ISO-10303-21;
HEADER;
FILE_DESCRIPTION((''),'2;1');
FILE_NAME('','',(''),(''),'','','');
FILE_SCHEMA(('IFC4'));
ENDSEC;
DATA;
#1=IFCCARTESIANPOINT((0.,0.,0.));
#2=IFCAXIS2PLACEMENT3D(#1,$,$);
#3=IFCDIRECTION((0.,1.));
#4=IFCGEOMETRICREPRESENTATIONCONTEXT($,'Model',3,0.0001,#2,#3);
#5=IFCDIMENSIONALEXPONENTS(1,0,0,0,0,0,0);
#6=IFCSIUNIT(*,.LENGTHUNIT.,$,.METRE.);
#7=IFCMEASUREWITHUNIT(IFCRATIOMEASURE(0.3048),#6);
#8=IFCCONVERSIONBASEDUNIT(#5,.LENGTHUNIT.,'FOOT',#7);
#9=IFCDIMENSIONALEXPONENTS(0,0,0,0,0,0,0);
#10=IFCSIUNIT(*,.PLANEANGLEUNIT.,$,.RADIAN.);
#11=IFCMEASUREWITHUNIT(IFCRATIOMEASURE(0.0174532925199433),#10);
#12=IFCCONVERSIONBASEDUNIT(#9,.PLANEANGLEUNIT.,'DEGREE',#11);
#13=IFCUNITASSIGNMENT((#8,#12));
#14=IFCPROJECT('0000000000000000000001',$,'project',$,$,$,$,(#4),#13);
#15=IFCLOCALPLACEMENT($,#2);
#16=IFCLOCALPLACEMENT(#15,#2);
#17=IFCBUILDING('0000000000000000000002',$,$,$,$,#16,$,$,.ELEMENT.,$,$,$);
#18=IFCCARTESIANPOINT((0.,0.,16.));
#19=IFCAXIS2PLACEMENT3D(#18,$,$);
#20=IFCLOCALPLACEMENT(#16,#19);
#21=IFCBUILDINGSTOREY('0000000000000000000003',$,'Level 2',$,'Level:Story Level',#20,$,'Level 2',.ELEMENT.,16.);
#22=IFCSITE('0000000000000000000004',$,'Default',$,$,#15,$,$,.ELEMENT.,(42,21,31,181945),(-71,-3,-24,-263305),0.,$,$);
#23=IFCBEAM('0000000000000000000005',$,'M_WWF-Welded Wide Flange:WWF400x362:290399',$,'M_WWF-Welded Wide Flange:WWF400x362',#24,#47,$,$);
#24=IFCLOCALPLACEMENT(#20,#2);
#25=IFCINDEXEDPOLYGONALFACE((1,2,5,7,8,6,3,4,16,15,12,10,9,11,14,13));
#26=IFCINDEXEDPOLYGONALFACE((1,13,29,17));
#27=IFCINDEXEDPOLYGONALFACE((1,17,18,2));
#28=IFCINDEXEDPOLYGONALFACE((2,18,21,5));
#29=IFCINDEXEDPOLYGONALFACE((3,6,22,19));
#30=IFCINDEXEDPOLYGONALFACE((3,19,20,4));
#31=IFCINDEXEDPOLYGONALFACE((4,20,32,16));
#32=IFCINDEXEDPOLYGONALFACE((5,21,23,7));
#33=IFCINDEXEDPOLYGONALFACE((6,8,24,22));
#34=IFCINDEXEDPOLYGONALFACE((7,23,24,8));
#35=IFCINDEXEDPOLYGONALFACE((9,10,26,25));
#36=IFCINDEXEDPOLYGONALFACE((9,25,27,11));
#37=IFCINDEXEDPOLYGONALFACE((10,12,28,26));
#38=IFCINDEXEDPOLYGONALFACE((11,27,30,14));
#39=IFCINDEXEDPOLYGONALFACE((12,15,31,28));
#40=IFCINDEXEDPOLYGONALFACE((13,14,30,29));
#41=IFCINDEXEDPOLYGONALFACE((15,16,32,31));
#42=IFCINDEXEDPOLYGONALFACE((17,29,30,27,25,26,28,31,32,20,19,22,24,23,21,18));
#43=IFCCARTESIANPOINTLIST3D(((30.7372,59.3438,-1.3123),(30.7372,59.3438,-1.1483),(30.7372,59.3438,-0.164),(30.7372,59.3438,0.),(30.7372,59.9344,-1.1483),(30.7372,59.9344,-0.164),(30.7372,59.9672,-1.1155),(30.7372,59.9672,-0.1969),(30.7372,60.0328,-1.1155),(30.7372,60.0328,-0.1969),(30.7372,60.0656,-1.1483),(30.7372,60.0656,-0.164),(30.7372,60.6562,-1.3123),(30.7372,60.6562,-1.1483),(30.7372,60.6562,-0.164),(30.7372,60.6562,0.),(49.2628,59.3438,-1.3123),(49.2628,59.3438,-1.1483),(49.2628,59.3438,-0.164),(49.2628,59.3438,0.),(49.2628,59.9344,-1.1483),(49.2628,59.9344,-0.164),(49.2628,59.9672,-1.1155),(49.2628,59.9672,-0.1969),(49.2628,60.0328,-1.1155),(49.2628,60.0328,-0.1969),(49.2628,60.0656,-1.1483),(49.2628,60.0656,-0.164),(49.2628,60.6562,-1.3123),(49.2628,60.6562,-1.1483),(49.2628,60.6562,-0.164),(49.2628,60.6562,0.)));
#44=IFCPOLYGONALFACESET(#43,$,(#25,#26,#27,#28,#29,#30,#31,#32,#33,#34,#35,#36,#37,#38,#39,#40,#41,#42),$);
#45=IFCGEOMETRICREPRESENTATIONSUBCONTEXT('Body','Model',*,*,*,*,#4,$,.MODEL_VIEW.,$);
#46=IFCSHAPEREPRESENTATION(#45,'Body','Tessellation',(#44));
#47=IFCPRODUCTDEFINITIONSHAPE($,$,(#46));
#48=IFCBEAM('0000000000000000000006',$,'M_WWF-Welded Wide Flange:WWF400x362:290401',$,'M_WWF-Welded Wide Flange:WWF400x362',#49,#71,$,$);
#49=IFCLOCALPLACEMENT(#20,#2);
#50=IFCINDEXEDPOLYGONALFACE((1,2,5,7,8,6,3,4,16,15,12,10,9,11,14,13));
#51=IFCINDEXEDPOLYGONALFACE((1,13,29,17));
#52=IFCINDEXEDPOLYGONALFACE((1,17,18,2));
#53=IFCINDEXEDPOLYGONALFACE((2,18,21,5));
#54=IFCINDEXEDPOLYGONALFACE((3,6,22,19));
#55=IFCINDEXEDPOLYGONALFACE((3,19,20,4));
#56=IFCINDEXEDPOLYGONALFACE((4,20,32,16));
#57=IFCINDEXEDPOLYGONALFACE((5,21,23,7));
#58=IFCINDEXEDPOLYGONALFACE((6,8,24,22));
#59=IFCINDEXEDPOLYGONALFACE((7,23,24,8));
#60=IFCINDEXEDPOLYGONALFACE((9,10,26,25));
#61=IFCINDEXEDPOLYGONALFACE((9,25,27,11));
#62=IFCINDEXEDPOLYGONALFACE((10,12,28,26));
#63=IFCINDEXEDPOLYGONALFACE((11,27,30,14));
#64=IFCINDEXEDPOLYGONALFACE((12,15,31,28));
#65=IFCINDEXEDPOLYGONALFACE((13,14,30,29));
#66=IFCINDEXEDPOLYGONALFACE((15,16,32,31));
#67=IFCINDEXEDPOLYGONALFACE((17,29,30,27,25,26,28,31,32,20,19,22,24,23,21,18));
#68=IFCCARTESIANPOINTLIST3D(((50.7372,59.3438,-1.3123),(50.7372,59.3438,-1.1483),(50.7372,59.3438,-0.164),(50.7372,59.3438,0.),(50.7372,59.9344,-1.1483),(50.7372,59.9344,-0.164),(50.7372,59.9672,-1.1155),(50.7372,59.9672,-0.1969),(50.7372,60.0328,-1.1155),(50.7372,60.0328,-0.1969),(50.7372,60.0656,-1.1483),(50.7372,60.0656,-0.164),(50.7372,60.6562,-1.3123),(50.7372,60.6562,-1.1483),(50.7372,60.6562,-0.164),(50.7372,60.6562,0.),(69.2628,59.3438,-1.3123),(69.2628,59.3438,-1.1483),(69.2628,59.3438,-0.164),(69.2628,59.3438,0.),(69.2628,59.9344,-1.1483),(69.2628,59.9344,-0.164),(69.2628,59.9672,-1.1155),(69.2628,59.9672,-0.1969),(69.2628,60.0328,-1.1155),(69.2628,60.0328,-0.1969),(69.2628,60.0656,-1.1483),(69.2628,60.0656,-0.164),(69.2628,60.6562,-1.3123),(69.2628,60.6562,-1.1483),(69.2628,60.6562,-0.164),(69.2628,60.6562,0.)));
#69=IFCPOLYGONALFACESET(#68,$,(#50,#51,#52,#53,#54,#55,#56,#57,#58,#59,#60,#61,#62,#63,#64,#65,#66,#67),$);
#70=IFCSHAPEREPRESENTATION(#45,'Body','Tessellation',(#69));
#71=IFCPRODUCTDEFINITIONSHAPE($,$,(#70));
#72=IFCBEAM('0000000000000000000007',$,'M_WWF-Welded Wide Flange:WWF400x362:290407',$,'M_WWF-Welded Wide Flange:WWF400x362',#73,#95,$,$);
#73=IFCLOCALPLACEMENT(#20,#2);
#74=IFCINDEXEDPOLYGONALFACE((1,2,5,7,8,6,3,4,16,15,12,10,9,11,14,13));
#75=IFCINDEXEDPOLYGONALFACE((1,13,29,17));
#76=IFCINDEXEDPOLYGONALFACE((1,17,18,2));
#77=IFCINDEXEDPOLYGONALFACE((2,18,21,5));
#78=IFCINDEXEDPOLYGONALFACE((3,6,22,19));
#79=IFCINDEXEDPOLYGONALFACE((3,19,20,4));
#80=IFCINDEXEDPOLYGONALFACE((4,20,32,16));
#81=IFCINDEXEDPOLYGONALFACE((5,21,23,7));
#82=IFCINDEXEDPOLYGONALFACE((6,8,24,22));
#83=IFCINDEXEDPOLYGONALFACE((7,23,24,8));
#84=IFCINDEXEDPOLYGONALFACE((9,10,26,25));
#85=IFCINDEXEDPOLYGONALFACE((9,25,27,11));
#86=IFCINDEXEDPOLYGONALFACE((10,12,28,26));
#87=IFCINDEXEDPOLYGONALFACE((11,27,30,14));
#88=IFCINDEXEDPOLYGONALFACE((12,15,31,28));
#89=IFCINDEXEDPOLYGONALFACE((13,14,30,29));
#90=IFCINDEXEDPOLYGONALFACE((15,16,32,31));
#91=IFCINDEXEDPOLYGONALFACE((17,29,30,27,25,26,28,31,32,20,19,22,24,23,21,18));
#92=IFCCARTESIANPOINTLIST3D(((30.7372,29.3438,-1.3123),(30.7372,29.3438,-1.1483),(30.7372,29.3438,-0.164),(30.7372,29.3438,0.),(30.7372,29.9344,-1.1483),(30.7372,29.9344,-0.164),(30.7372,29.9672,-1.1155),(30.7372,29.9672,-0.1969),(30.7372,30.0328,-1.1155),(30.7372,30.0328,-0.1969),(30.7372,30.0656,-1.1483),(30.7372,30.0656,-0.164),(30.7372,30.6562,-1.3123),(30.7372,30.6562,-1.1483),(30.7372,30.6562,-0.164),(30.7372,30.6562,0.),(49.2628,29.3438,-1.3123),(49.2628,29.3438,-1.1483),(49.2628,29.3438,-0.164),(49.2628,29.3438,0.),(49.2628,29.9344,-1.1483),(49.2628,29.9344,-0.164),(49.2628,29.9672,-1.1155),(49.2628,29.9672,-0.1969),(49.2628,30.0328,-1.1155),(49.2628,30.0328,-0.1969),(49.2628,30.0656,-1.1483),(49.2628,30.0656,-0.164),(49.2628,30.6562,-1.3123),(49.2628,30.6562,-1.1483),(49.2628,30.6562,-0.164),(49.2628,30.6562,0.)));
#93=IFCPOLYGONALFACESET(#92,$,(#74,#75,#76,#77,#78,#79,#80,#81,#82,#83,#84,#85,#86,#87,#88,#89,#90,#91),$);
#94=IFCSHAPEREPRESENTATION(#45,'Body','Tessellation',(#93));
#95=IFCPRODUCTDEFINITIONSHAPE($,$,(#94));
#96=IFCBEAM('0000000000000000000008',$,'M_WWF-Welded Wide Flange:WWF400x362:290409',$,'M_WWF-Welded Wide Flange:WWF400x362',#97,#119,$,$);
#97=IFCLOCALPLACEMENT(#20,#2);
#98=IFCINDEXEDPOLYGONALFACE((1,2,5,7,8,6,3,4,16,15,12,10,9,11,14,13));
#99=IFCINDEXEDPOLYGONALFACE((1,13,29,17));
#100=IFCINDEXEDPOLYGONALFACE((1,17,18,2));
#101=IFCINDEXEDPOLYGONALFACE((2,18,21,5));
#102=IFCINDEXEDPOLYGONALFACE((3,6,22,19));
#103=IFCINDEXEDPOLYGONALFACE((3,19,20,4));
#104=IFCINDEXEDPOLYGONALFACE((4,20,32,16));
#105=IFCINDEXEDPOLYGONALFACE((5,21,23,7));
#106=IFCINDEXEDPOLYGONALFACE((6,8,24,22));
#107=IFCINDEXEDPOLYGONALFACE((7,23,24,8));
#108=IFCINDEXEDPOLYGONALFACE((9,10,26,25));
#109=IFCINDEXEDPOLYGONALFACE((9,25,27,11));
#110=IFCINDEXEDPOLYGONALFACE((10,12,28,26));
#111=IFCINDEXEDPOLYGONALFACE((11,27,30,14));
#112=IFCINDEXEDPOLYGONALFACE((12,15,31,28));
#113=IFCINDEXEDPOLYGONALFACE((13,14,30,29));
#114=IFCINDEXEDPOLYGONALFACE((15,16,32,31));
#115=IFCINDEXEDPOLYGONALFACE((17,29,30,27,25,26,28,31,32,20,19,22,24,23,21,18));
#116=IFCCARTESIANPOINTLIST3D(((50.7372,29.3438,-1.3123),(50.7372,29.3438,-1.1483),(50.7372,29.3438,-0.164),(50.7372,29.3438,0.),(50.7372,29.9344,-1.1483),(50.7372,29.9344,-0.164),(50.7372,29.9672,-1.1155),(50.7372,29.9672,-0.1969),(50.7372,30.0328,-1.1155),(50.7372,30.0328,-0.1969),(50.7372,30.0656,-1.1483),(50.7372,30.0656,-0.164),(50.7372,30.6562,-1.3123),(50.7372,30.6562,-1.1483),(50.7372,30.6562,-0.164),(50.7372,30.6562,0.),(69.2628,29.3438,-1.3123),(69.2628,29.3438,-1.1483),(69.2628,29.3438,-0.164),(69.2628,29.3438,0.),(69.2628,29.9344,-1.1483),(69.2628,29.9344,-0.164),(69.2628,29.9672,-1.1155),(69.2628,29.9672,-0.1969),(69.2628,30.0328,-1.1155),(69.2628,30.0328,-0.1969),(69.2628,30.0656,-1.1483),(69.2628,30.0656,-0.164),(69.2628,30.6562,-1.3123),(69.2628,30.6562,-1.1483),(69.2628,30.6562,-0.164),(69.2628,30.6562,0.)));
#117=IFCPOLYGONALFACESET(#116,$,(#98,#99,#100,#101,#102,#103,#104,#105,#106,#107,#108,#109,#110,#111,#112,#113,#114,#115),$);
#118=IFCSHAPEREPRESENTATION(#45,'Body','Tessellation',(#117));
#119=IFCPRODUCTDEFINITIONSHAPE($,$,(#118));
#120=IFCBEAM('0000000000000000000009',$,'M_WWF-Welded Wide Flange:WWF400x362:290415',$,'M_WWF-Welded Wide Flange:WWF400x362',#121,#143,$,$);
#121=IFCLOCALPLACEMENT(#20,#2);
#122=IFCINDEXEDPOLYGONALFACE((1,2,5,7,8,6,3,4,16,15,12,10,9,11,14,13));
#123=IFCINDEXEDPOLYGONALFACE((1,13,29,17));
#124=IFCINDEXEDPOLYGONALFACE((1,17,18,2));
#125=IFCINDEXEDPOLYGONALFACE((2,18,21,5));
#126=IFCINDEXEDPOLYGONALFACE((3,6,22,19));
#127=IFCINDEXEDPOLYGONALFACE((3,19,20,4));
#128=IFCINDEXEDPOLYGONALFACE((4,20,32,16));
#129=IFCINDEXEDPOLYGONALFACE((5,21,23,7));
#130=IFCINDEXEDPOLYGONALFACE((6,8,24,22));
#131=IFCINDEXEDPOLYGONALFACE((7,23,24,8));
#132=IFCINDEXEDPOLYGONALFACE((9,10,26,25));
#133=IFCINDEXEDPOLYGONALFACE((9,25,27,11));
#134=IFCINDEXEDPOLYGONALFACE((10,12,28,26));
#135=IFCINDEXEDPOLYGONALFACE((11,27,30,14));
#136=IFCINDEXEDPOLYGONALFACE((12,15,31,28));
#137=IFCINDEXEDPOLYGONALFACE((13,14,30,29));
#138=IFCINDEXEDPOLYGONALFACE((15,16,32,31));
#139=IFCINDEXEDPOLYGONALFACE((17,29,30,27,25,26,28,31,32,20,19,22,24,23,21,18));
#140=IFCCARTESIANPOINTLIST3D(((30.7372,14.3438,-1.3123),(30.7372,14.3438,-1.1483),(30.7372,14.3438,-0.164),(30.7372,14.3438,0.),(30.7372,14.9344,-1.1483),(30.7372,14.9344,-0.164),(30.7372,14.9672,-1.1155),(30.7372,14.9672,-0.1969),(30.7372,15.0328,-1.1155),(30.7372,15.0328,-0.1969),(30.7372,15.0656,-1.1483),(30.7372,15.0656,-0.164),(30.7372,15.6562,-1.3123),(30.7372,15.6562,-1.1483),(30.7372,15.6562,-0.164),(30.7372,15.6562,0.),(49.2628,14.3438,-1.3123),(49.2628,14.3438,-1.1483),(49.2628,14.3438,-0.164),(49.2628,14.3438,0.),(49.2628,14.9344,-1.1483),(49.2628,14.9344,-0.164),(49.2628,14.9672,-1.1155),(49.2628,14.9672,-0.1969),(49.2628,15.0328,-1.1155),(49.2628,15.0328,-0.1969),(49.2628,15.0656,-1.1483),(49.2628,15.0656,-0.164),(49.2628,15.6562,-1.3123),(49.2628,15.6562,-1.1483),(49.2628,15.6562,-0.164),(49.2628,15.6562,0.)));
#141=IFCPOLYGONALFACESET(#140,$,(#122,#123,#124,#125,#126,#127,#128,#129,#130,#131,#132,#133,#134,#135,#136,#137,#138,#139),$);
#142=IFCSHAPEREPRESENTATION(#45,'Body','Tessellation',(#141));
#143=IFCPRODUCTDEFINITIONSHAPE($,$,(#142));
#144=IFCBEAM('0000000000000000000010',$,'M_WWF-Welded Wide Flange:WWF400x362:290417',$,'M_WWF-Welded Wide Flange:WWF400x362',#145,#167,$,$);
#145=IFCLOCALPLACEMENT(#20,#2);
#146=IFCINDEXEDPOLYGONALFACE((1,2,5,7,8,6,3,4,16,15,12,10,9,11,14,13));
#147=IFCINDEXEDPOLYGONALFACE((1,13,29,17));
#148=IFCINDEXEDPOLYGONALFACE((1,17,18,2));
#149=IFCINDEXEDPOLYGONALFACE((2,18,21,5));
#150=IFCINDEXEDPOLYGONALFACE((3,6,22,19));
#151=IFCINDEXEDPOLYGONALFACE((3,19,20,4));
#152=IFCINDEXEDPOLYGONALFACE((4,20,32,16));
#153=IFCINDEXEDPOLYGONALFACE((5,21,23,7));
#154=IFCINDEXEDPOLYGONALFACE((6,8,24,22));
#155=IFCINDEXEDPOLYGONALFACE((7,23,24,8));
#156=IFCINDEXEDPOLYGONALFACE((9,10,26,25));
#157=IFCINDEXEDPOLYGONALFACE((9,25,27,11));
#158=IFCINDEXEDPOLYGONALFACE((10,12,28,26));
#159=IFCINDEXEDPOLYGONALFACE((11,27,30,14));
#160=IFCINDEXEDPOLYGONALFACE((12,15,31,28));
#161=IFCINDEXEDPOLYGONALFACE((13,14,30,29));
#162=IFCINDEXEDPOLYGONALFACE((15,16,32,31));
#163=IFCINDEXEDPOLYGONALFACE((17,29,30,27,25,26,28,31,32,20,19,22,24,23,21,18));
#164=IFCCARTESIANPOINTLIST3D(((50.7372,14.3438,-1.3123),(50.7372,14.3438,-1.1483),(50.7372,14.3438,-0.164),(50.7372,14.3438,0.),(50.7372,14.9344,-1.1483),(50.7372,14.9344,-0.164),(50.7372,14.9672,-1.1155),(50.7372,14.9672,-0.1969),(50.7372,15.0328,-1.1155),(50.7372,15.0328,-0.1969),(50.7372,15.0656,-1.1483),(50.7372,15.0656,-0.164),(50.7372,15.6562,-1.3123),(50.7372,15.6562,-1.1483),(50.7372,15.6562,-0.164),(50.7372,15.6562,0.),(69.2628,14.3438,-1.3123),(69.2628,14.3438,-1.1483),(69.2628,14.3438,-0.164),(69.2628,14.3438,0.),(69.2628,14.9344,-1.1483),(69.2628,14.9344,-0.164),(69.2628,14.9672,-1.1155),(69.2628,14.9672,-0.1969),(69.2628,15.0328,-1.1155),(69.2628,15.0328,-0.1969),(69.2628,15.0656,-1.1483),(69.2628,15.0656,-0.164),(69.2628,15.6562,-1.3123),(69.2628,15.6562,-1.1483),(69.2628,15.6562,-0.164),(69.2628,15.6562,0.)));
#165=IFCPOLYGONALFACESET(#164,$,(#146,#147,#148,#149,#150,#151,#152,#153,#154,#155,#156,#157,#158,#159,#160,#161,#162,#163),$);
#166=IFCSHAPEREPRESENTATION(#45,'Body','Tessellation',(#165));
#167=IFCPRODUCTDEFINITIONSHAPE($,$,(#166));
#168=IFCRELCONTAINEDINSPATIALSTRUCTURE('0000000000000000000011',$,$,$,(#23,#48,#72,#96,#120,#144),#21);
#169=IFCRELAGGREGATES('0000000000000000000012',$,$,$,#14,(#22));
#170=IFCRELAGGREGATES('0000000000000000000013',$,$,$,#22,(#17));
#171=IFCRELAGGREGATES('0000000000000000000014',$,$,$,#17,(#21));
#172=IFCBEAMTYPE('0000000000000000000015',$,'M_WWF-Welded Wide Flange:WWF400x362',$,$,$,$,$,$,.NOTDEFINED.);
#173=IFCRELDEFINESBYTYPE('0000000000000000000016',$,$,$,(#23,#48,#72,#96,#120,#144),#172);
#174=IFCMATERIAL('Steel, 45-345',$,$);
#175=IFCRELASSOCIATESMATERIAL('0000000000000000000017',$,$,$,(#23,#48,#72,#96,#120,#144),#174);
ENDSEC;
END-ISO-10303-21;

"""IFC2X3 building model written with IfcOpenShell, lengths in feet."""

from ifc_helpers import new_model, entity, si_unit, converted_unit, direction, frame, origin, place, context, subcontext, project, spatial, polyline, outline, extrude, material, type_object, element, save


model = new_model("IFC2X3")

# Units and contexts
model_context = context("Model", 3, precision=0.0001, world=origin(), true_north=direction((0.0, 1.0)))
body_context = subcontext(model_context, "Body", "Model", "MODEL_VIEW")
ifc_project = project(units=[converted_unit("LENGTHUNIT", "FOOT", entity("IfcRatioMeasure", 0.3048), si_unit("LENGTHUNIT", "METRE"), dimensions=[1, 0, 0, 0, 0, 0, 0]), converted_unit("PLANEANGLEUNIT", "DEGREE", entity("IfcRatioMeasure", 0.0174532925199433), si_unit("PLANEANGLEUNIT", "RADIAN"), dimensions=[0, 0, 0, 0, 0, 0, 0])], contexts=[model_context])

# Site, building, storey
site_placement = place(None, origin())
site = spatial("IfcSite", under=ifc_project, at=site_placement, Name="Default", CompositionType="ELEMENT", RefLatitude=(42, 21, 31, 181945), RefLongitude=(-71, -3, -24, -263305), RefElevation=0.0)
building_placement = place(site_placement, origin())
building = spatial("IfcBuilding", under=site, at=building_placement, CompositionType="ELEMENT")
storey_placement = place(building_placement, frame((0.0, 0.0, 16.0)))
storey = spatial("IfcBuildingStorey", under=building, at=storey_placement, Name="Level 2", ObjectType="Level:Story Level", LongName="Level 2", CompositionType="ELEMENT", Elevation=16.0)

# Shared definitions
ifc_material = material(Name="Steel, 45-345")

# Beams
beam_type = type_object("IfcBeamType", Name="M_WWF-Welded Wide Flange:WWF400x362", PredefinedType="NOTDEFINED")
beam_1_placement = place(storey_placement, frame((30.0, 60.0, 0.0)))
element("IfcBeam", 1, at=beam_1_placement, inside=storey, type_object=beam_type, material=ifc_material, Name="M_WWF-Welded Wide Flange:WWF400x362:290399", ObjectType="M_WWF-Welded Wide Flange:WWF400x362", context=body_context, shape_type="SweptSolid", body=[
    extrude(outline(polyline([(-0.6562, -0.6562), (-0.4921, -0.6562), (-0.4921, -0.0656), (-0.4593, -0.0328), (0.4593, -0.0328), (0.4921, -0.0656), (0.4921, -0.6562), (0.6562, -0.6562), (0.6562, 0.6562), (0.4921, 0.6562), (0.4921, 0.0656), (0.4593, 0.0328), (-0.4593, 0.0328), (-0.4921, 0.0656), (-0.4921, 0.6562), (-0.6562, 0.6562), (-0.6562, -0.6562)])), frame((0.7372, 0.0, -0.6562), z_axis=(1.0, 0.0, 0.0), x_axis=(0.0, 0.0, -1.0)), (0.0, 0.0, 1.0), 18.5256),
])
beam_2_placement = place(storey_placement, frame((50.0, 60.0, 0.0)))
element("IfcBeam", 2, at=beam_2_placement, inside=storey, type_object=beam_type, material=ifc_material, Name="M_WWF-Welded Wide Flange:WWF400x362:290401", ObjectType="M_WWF-Welded Wide Flange:WWF400x362", context=body_context, shape_type="SweptSolid", body=[
    extrude(outline(polyline([(-0.6562, -0.6562), (-0.4921, -0.6562), (-0.4921, -0.0656), (-0.4593, -0.0328), (0.4593, -0.0328), (0.4921, -0.0656), (0.4921, -0.6562), (0.6562, -0.6562), (0.6562, 0.6562), (0.4921, 0.6562), (0.4921, 0.0656), (0.4593, 0.0328), (-0.4593, 0.0328), (-0.4921, 0.0656), (-0.4921, 0.6562), (-0.6562, 0.6562), (-0.6562, -0.6562)])), frame((0.7372, 0.0, -0.6562), z_axis=(1.0, 0.0, 0.0), x_axis=(0.0, 0.0, -1.0)), (0.0, 0.0, 1.0), 18.5256),
])
beam_3_placement = place(storey_placement, frame((30.0, 30.0, 0.0)))
element("IfcBeam", 3, at=beam_3_placement, inside=storey, type_object=beam_type, material=ifc_material, Name="M_WWF-Welded Wide Flange:WWF400x362:290407", ObjectType="M_WWF-Welded Wide Flange:WWF400x362", context=body_context, shape_type="SweptSolid", body=[
    extrude(outline(polyline([(-0.6562, -0.6562), (-0.4921, -0.6562), (-0.4921, -0.0656), (-0.4593, -0.0328), (0.4593, -0.0328), (0.4921, -0.0656), (0.4921, -0.6562), (0.6562, -0.6562), (0.6562, 0.6562), (0.4921, 0.6562), (0.4921, 0.0656), (0.4593, 0.0328), (-0.4593, 0.0328), (-0.4921, 0.0656), (-0.4921, 0.6562), (-0.6562, 0.6562), (-0.6562, -0.6562)])), frame((0.7372, 0.0, -0.6562), z_axis=(1.0, 0.0, 0.0), x_axis=(0.0, 0.0, -1.0)), (0.0, 0.0, 1.0), 18.5256),
])
beam_4_placement = place(storey_placement, frame((50.0, 30.0, 0.0)))
element("IfcBeam", 4, at=beam_4_placement, inside=storey, type_object=beam_type, material=ifc_material, Name="M_WWF-Welded Wide Flange:WWF400x362:290409", ObjectType="M_WWF-Welded Wide Flange:WWF400x362", context=body_context, shape_type="SweptSolid", body=[
    extrude(outline(polyline([(-0.6562, -0.6562), (-0.4921, -0.6562), (-0.4921, -0.0656), (-0.4593, -0.0328), (0.4593, -0.0328), (0.4921, -0.0656), (0.4921, -0.6562), (0.6562, -0.6562), (0.6562, 0.6562), (0.4921, 0.6562), (0.4921, 0.0656), (0.4593, 0.0328), (-0.4593, 0.0328), (-0.4921, 0.0656), (-0.4921, 0.6562), (-0.6562, 0.6562), (-0.6562, -0.6562)])), frame((0.7372, 0.0, -0.6562), z_axis=(1.0, 0.0, 0.0), x_axis=(0.0, 0.0, -1.0)), (0.0, 0.0, 1.0), 18.5256),
])
beam_5_placement = place(storey_placement, frame((30.0, 15.0, 0.0)))
element("IfcBeam", 5, at=beam_5_placement, inside=storey, type_object=beam_type, material=ifc_material, Name="M_WWF-Welded Wide Flange:WWF400x362:290415", ObjectType="M_WWF-Welded Wide Flange:WWF400x362", context=body_context, shape_type="SweptSolid", body=[
    extrude(outline(polyline([(-0.6562, -0.6562), (-0.4921, -0.6562), (-0.4921, -0.0656), (-0.4593, -0.0328), (0.4593, -0.0328), (0.4921, -0.0656), (0.4921, -0.6562), (0.6562, -0.6562), (0.6562, 0.6562), (0.4921, 0.6562), (0.4921, 0.0656), (0.4593, 0.0328), (-0.4593, 0.0328), (-0.4921, 0.0656), (-0.4921, 0.6562), (-0.6562, 0.6562), (-0.6562, -0.6562)])), frame((0.7372, 0.0, -0.6562), z_axis=(1.0, 0.0, 0.0), x_axis=(0.0, 0.0, -1.0)), (0.0, 0.0, 1.0), 18.5256),
])
beam_6_placement = place(storey_placement, frame((50.0, 15.0, 0.0)))
element("IfcBeam", 6, at=beam_6_placement, inside=storey, type_object=beam_type, material=ifc_material, Name="M_WWF-Welded Wide Flange:WWF400x362:290417", ObjectType="M_WWF-Welded Wide Flange:WWF400x362", context=body_context, shape_type="SweptSolid", body=[
    extrude(outline(polyline([(-0.6562, -0.6562), (-0.4921, -0.6562), (-0.4921, -0.0656), (-0.4593, -0.0328), (0.4593, -0.0328), (0.4921, -0.0656), (0.4921, -0.6562), (0.6562, -0.6562), (0.6562, 0.6562), (0.4921, 0.6562), (0.4921, 0.0656), (0.4593, 0.0328), (-0.4593, 0.0328), (-0.4921, 0.0656), (-0.4921, 0.6562), (-0.6562, 0.6562), (-0.6562, -0.6562)])), frame((0.7372, 0.0, -0.6562), z_axis=(1.0, 0.0, 0.0), x_axis=(0.0, 0.0, -1.0)), (0.0, 0.0, 1.0), 18.5256),
])

save(model, "model.ifc")
